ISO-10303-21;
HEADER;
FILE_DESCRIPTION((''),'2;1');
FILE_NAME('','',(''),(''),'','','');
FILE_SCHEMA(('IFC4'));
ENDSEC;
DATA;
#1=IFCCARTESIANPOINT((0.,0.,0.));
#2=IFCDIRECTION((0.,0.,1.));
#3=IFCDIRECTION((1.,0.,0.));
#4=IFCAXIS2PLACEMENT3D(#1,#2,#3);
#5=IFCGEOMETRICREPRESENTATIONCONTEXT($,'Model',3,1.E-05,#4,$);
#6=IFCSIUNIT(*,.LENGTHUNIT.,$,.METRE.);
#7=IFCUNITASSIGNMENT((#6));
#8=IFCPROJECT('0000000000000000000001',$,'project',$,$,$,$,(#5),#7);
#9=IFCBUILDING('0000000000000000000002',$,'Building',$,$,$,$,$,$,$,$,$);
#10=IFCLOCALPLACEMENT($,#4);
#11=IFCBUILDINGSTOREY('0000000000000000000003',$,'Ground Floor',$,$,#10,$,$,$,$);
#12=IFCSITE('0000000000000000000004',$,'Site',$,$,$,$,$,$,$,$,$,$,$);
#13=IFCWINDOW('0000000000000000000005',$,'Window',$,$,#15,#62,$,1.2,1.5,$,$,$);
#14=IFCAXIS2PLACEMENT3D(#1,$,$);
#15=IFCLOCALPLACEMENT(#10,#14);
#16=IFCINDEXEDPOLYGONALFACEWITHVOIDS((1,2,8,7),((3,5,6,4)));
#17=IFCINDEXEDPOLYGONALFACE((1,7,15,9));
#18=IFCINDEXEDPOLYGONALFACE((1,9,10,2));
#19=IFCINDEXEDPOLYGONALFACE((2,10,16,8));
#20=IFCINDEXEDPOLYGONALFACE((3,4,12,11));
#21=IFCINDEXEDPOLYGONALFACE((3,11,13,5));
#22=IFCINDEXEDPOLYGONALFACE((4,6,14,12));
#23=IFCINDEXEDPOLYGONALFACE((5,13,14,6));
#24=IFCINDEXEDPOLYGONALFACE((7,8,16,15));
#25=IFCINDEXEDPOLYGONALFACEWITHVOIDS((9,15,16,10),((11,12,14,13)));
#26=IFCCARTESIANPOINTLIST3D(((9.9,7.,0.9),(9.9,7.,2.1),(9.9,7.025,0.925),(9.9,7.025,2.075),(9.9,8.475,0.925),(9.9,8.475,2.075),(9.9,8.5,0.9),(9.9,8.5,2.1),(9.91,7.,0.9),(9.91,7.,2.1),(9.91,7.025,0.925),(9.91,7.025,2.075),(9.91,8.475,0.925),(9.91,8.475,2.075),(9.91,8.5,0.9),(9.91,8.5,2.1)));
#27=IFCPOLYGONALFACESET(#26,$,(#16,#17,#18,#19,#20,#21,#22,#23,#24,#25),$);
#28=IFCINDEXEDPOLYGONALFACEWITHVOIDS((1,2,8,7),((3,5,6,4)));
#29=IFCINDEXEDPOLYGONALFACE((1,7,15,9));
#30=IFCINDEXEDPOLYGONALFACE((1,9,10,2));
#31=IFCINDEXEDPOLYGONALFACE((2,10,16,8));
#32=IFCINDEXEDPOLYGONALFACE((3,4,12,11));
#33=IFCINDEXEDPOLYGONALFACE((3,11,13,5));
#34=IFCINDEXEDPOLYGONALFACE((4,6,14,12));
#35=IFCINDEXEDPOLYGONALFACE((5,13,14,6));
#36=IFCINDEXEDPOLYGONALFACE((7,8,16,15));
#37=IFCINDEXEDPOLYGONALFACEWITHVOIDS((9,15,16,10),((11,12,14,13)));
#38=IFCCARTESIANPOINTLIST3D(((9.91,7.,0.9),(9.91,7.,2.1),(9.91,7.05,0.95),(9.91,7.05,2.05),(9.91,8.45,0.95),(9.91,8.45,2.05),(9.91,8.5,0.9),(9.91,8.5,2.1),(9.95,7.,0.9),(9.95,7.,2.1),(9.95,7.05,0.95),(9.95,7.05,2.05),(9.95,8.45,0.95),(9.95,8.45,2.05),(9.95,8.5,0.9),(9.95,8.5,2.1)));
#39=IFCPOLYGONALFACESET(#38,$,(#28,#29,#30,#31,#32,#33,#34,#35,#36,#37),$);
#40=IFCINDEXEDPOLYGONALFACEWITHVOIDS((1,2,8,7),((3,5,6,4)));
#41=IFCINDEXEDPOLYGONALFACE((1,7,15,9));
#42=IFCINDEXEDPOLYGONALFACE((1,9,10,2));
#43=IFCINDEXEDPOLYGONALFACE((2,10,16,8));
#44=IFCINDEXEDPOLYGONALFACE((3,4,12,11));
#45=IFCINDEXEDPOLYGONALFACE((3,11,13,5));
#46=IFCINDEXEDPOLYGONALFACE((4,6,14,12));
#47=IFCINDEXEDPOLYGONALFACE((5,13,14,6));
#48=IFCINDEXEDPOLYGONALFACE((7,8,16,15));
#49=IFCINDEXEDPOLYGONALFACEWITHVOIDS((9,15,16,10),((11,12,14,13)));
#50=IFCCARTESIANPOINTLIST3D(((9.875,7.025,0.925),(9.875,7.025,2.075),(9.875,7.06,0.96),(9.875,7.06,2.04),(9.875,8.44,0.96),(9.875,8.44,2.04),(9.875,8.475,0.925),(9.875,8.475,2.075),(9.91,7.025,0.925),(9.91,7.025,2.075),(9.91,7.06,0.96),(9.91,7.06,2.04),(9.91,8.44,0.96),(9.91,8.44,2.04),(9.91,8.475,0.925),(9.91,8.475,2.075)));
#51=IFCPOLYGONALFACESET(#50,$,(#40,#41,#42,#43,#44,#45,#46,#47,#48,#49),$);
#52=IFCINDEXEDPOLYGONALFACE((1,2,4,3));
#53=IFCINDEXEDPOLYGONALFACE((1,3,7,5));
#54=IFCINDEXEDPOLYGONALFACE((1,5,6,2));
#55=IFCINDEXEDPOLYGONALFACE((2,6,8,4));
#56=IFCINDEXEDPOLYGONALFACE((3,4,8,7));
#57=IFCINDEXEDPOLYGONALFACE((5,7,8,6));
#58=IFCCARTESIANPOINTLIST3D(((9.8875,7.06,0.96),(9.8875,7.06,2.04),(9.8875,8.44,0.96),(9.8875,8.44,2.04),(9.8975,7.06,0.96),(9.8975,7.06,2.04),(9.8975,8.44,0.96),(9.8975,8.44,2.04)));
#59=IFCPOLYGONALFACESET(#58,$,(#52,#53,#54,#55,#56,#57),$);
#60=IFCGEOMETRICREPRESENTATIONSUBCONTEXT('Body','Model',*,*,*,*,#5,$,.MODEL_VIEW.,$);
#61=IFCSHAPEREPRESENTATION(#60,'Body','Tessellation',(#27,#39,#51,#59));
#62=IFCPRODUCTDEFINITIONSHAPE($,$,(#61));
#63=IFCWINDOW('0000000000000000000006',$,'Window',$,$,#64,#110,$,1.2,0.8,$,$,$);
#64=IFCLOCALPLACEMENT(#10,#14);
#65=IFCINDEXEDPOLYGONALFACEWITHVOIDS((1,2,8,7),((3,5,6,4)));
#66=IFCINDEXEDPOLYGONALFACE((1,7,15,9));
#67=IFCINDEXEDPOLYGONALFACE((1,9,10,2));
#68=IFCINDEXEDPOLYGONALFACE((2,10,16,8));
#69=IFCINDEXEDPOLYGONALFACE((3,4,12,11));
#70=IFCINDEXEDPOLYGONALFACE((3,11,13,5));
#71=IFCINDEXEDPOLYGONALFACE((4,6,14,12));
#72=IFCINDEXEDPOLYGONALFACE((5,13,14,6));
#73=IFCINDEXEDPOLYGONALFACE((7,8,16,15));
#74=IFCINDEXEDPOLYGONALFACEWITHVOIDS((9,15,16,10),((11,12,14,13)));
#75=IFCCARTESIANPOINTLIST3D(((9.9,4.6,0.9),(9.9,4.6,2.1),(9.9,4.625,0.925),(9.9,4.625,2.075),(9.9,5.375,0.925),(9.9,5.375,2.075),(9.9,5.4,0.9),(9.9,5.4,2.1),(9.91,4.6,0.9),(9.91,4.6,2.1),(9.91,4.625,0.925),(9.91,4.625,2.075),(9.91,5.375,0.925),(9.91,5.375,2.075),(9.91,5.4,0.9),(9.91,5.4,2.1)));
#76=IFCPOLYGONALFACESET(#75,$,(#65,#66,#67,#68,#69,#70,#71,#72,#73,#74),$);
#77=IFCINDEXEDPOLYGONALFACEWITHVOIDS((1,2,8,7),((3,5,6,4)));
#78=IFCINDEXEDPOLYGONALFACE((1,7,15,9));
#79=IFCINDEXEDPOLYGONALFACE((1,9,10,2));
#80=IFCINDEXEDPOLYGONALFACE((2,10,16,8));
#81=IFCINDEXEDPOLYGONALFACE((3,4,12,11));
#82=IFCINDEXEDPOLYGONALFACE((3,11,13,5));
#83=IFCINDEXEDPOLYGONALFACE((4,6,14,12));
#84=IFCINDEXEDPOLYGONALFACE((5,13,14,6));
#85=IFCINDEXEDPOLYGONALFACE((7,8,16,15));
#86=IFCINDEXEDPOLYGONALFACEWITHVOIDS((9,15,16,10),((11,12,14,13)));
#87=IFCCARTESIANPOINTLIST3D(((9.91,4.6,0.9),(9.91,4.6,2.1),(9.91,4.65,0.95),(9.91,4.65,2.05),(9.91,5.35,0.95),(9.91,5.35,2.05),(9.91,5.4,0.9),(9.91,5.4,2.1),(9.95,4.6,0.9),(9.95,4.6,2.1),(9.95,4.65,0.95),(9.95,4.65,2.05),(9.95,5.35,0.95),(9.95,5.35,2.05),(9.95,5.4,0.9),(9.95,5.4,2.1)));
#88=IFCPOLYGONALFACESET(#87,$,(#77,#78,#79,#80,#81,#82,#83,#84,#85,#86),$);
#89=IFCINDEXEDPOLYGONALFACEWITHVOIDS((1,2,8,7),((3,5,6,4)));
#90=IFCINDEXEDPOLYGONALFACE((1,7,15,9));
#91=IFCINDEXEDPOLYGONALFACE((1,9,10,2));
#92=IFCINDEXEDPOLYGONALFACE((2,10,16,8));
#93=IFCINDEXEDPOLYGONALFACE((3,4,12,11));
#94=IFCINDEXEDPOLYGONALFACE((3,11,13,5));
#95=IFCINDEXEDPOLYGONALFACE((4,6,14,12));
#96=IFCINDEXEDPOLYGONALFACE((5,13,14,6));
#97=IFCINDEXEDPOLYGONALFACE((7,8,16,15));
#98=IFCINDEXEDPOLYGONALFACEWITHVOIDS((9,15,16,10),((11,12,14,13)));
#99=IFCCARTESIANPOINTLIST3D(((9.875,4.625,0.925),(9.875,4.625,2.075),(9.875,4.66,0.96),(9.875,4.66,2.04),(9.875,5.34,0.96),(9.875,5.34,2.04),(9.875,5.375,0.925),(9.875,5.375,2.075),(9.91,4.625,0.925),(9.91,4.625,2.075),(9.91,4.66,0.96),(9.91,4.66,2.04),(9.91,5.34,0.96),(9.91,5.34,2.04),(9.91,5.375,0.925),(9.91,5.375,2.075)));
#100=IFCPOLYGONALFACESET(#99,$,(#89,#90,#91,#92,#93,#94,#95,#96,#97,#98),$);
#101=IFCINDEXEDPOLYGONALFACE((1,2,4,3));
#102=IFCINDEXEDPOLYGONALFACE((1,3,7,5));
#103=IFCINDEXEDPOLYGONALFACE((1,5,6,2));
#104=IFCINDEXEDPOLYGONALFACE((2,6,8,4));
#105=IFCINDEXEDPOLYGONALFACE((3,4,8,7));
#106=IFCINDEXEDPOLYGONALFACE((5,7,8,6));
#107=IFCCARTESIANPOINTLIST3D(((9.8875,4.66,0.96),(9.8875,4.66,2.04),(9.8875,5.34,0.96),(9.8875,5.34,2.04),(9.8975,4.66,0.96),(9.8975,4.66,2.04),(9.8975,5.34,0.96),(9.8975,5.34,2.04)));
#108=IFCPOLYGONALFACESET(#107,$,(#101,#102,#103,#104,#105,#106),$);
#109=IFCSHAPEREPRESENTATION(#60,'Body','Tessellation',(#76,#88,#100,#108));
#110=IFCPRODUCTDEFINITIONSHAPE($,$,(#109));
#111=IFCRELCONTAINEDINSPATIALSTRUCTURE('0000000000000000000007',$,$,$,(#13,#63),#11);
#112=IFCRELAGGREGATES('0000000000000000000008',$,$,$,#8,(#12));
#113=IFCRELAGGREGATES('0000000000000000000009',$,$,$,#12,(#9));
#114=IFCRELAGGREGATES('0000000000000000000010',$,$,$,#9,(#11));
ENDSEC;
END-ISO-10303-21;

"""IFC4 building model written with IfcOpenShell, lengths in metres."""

from ifc_helpers import new_model, si_unit, frame, origin_with_axes, place, context, subcontext, project, spatial, line, indexed_curve, outline, extrude, element, save


model = new_model("IFC4")

# Units and contexts
model_context = context("Model", 3, precision=1e-05, world=origin_with_axes())
body_context = subcontext(model_context, "Body", "Model", "MODEL_VIEW")
ifc_project = project(units=[si_unit("LENGTHUNIT", "METRE")], contexts=[model_context])

# Site, building, storey
site = spatial("IfcSite", under=ifc_project, Name="Site")
building = spatial("IfcBuilding", under=site, Name="Building")
storey_placement = place(None, origin_with_axes())
storey = spatial("IfcBuildingStorey", under=building, at=storey_placement, Name="Ground Floor")

# Windows
window_1_placement = place(storey_placement, frame((10.0, 7.0, 0.9), z_axis=(0.0, 0.0, 1.0), x_axis=(0.0, 1.0, 0.0)))
element("IfcWindow", 1, at=window_1_placement, inside=storey, Name="Window", OverallHeight=1.2, OverallWidth=1.5, context=body_context, shape_type="SweptSolid", body=[
    extrude(outline(indexed_curve([(0.0, 0.0), (1.5, 0.0), (1.5, 1.2), (0.0, 1.2)], segments=[line(1, 2, 3, 4, 1)]), holes=[indexed_curve([(0.025, 0.025), (1.475, 0.025), (1.475, 1.175), (0.025, 1.175)], segments=[line(1, 2, 3, 4, 1)])]), frame((0.0, 0.09, 0.0), z_axis=(0.0, -1.0, 0.0), x_axis=(1.0, 0.0, 0.0)), (0.0, 0.0, -1.0), 0.01),
    extrude(outline(indexed_curve([(0.0, 0.0), (1.5, 0.0), (1.5, 1.2), (0.0, 1.2)], segments=[line(1, 2, 3, 4, 1)]), holes=[indexed_curve([(0.05, 0.05), (1.45, 0.05), (1.45, 1.15), (0.05, 1.15)], segments=[line(1, 2, 3, 4, 1)])]), frame((0.0, 0.05, 0.0), z_axis=(0.0, -1.0, 0.0), x_axis=(1.0, 0.0, 0.0)), (0.0, 0.0, -1.0), 0.04),
    extrude(outline(indexed_curve([(0.0, 0.0), (1.45, 0.0), (1.45, 1.15), (0.0, 1.15)], segments=[line(1, 2, 3, 4, 1)]), holes=[indexed_curve([(0.035, 0.035), (1.415, 0.035), (1.415, 1.115), (0.035, 1.115)], segments=[line(1, 2, 3, 4, 1)])]), frame((0.025, 0.09, 0.025), z_axis=(0.0, -1.0, 0.0), x_axis=(1.0, 0.0, 0.0)), (0.0, 0.0, -1.0), 0.035),
    extrude(outline(indexed_curve([(0.035, 0.035), (1.415, 0.035), (1.415, 1.115), (0.035, 1.115)], segments=[line(1, 2, 3, 4, 1)])), frame((0.025, 0.1025, 0.025), z_axis=(0.0, -1.0, 0.0), x_axis=(1.0, 0.0, 0.0)), (0.0, 0.0, -1.0), 0.01),
])
window_2_placement = place(storey_placement, frame((10.0, 4.6, 0.9), z_axis=(0.0, 0.0, 1.0), x_axis=(0.0, 1.0, 0.0)))
element("IfcWindow", 2, at=window_2_placement, inside=storey, Name="Window", OverallHeight=1.2, OverallWidth=0.8, context=body_context, shape_type="SweptSolid", body=[
    extrude(outline(indexed_curve([(0.0, 0.0), (0.8, 0.0), (0.8, 1.2), (0.0, 1.2)], segments=[line(1, 2, 3, 4, 1)]), holes=[indexed_curve([(0.025, 0.025), (0.775, 0.025), (0.775, 1.175), (0.025, 1.175)], segments=[line(1, 2, 3, 4, 1)])]), frame((0.0, 0.09, 0.0), z_axis=(0.0, -1.0, 0.0), x_axis=(1.0, 0.0, 0.0)), (0.0, 0.0, -1.0), 0.01),
    extrude(outline(indexed_curve([(0.0, 0.0), (0.8, 0.0), (0.8, 1.2), (0.0, 1.2)], segments=[line(1, 2, 3, 4, 1)]), holes=[indexed_curve([(0.05, 0.05), (0.75, 0.05), (0.75, 1.15), (0.05, 1.15)], segments=[line(1, 2, 3, 4, 1)])]), frame((0.0, 0.05, 0.0), z_axis=(0.0, -1.0, 0.0), x_axis=(1.0, 0.0, 0.0)), (0.0, 0.0, -1.0), 0.04),
    extrude(outline(indexed_curve([(0.0, 0.0), (0.75, 0.0), (0.75, 1.15), (0.0, 1.15)], segments=[line(1, 2, 3, 4, 1)]), holes=[indexed_curve([(0.035, 0.035), (0.715, 0.035), (0.715, 1.115), (0.035, 1.115)], segments=[line(1, 2, 3, 4, 1)])]), frame((0.025, 0.09, 0.025), z_axis=(0.0, -1.0, 0.0), x_axis=(1.0, 0.0, 0.0)), (0.0, 0.0, -1.0), 0.035),
    extrude(outline(indexed_curve([(0.035, 0.035), (0.715, 0.035), (0.715, 1.115), (0.035, 1.115)], segments=[line(1, 2, 3, 4, 1)])), frame((0.025, 0.1025, 0.025), z_axis=(0.0, -1.0, 0.0), x_axis=(1.0, 0.0, 0.0)), (0.0, 0.0, -1.0), 0.01),
])

save(model, "model.ifc")
